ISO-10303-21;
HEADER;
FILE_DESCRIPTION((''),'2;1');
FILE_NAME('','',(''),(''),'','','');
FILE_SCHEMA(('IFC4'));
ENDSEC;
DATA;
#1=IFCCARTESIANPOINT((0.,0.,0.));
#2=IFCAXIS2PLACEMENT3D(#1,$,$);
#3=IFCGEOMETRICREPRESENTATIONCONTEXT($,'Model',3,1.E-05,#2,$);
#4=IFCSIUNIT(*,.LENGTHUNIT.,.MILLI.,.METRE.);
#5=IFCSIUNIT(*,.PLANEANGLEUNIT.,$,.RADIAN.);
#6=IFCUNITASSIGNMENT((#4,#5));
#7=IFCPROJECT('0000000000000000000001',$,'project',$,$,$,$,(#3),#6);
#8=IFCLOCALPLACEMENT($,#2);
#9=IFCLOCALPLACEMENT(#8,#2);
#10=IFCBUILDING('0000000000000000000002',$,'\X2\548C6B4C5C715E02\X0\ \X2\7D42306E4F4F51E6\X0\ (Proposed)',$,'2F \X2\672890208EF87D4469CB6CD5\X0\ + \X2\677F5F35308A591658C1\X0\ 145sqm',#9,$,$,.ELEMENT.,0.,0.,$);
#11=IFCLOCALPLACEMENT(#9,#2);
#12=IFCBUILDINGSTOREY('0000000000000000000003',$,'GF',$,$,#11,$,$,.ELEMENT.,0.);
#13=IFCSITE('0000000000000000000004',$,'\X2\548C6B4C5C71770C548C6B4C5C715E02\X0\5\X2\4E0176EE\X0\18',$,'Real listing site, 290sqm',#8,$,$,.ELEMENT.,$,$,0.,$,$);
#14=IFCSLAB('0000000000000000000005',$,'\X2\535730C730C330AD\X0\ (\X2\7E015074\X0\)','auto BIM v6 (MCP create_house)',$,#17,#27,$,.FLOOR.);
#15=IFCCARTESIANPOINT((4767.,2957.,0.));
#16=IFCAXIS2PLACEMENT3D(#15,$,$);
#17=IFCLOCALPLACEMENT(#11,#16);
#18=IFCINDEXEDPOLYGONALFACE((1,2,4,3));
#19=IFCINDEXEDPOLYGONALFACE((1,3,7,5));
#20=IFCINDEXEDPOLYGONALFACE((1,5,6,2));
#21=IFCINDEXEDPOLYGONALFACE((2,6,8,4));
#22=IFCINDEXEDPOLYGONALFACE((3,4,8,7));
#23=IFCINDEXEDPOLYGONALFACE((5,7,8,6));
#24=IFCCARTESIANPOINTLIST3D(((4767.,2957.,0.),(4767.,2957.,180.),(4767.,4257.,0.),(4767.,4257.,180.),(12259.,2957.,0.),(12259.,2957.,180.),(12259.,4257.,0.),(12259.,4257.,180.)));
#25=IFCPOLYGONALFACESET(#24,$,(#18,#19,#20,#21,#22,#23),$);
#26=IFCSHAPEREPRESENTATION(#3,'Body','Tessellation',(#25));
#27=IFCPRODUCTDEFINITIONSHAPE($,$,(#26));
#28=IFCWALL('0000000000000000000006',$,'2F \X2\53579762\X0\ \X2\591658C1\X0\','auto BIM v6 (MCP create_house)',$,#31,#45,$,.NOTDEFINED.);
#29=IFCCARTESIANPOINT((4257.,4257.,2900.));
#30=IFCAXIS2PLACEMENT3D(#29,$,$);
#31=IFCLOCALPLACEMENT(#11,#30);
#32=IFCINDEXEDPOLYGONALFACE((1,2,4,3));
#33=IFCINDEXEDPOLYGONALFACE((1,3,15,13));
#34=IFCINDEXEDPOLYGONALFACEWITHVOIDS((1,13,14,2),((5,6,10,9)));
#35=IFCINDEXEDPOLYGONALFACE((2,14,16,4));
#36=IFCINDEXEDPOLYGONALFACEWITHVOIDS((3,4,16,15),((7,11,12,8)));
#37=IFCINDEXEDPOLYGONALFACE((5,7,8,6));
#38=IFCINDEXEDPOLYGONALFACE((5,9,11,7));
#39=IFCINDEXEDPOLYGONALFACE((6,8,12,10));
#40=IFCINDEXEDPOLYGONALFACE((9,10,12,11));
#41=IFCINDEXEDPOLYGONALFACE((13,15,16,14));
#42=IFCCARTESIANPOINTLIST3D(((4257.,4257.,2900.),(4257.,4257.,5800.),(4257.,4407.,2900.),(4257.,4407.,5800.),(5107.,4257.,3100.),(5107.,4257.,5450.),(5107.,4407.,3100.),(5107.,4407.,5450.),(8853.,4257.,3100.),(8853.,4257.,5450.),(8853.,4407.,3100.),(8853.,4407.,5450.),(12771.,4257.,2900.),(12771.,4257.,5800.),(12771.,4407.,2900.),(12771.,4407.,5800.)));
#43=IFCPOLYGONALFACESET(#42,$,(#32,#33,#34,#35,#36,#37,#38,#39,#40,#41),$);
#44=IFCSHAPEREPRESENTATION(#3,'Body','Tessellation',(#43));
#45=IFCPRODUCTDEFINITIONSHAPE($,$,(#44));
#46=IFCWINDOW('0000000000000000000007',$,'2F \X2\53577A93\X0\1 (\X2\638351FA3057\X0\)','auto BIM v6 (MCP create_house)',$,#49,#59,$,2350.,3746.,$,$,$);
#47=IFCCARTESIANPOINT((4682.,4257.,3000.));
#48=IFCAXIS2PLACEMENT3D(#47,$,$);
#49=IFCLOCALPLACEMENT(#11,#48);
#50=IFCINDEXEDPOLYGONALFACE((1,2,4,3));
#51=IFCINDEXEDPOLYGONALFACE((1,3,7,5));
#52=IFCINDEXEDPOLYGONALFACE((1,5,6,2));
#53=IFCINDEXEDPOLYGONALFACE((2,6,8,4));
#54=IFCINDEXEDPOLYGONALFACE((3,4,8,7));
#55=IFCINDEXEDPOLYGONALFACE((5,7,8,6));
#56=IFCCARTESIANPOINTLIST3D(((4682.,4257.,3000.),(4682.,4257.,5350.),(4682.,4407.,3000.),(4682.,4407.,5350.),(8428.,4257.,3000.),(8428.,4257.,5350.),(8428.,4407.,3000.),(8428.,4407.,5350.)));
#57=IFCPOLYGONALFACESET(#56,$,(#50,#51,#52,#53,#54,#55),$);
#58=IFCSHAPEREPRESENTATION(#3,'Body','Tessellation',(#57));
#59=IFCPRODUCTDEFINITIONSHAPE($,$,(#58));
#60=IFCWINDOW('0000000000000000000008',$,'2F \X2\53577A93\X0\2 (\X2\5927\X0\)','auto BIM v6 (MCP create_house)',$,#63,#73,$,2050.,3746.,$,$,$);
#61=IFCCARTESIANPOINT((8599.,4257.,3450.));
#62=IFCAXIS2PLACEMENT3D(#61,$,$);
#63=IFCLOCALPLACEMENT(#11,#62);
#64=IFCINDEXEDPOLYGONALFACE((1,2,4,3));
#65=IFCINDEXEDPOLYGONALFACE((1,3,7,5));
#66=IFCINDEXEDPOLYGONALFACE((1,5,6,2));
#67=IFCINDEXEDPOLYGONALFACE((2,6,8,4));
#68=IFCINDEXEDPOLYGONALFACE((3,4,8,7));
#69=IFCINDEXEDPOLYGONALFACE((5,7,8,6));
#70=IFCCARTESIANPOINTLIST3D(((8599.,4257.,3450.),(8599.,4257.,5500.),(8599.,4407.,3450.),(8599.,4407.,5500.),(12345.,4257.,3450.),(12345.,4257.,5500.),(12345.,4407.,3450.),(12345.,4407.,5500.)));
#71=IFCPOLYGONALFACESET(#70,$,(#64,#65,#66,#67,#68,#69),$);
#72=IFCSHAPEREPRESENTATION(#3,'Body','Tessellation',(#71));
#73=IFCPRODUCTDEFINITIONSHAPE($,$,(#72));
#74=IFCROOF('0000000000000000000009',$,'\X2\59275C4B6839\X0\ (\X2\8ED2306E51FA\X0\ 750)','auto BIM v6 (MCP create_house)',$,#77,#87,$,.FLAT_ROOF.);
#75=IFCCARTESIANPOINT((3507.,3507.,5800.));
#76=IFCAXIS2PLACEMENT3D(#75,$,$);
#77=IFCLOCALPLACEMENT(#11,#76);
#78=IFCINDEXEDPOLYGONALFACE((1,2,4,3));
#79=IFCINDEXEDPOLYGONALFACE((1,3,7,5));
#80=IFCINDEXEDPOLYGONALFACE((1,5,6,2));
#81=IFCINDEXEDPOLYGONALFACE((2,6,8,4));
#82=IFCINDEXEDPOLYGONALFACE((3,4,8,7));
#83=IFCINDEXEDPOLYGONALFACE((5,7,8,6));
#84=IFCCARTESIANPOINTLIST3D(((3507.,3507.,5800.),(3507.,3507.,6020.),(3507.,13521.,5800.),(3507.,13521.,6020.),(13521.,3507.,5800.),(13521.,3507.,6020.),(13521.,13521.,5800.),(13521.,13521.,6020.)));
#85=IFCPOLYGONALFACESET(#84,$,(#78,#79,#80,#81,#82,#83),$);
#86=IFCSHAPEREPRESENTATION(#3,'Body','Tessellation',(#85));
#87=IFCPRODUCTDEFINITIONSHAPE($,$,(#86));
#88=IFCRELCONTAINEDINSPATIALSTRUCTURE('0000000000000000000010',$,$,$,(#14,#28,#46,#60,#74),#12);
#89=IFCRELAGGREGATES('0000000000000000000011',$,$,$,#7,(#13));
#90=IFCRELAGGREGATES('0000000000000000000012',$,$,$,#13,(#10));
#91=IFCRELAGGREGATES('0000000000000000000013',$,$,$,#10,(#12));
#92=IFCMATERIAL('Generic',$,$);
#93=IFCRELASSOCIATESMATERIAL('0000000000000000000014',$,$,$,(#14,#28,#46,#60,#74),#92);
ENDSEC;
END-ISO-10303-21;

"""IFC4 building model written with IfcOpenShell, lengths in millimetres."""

from ifc_helpers import new_model, si_unit, frame, frame_2d, origin, place, context, project, spatial, rectangle, extrude, material, element, fill, save


model = new_model("IFC4")

# Units and contexts
model_context = context("Model", 3, precision=1e-05, world=origin())
ifc_project = project(units=[si_unit("LENGTHUNIT", "METRE", prefix="MILLI"), si_unit("PLANEANGLEUNIT", "RADIAN")], contexts=[model_context])

# Site, building, storey
site_placement = place(None, origin())
site = spatial("IfcSite", under=ifc_project, at=site_placement, Name="和歌山県和歌山市5丁目18", ObjectType="Real listing site, 290sqm", CompositionType="ELEMENT", RefElevation=0.0)
building_placement = place(site_placement, origin())
building = spatial("IfcBuilding", under=site, at=building_placement, Name="和歌山市 終の住処 (Proposed)", ObjectType="2F 木造軸組構法 + 板張り外壁 145sqm", CompositionType="ELEMENT", ElevationOfRefHeight=0.0, ElevationOfTerrain=0.0)
storey_placement = place(building_placement, origin())
storey = spatial("IfcBuildingStorey", under=building, at=storey_placement, Name="GF", CompositionType="ELEMENT", Elevation=0.0)

# Slab
ifc_material = material(Name="Generic")
slab_1_placement = place(storey_placement, frame((4767.0, 2957.0, 0.0)))
element("IfcSlab", 1, at=slab_1_placement, inside=storey, material=ifc_material, Name="南デッキ (縁側)", Description="auto BIM v6 (MCP create_house)", PredefinedType="FLOOR", context=model_context, shape_type="SweptSolid", body=[
    extrude(rectangle(XDim=7492.0, YDim=1300.0, at=frame_2d((3746.0, 650.0))), frame((4767.0, 2957.0, 0.0)), (0.0, 0.0, 1.0), 180.0),
])

# Wall, openings, windows
wall_1_placement = place(storey_placement, frame((4257.0, 4257.0, 2900.0)))
wall_1 = element("IfcWall", 2, at=wall_1_placement, inside=storey, material=ifc_material, Name="2F 南面 外壁", Description="auto BIM v6 (MCP create_house)", PredefinedType="NOTDEFINED", context=model_context, shape_type="SweptSolid", body=[
    extrude(rectangle(XDim=8514.0, YDim=150.0, at=frame_2d((4257.0, 75.0))), frame((4257.0, 4257.0, 2900.0)), (0.0, 0.0, 1.0), 2900.0),
])
opening_1_placement = place(storey_placement, frame((4682.0, 4257.0, 3000.0)))
opening_1 = element("IfcOpeningElement", 3, at=opening_1_placement, cuts=wall_1, PredefinedType="NOTDEFINED", context=model_context, shape_type="SweptSolid", body=[
    extrude(rectangle(XDim=3746.0, YDim=150.0, at=frame_2d((1873.0, 75.0))), frame((4682.0, 4257.0, 3000.0)), (0.0, 0.0, 1.0), 2350.0),
])
opening_2_placement = place(storey_placement, frame((8599.0, 4257.0, 3450.0)))
opening_2 = element("IfcOpeningElement", 4, at=opening_2_placement, cuts=wall_1, PredefinedType="NOTDEFINED", context=model_context, shape_type="SweptSolid", body=[
    extrude(rectangle(XDim=3746.0, YDim=150.0, at=frame_2d((1873.0, 75.0))), frame((8599.0, 4257.0, 3450.0)), (0.0, 0.0, 1.0), 2050.0),
])
window_1_placement = place(storey_placement, frame((4682.0, 4257.0, 3000.0)))
window_1 = element("IfcWindow", 5, at=window_1_placement, inside=storey, material=ifc_material, Name="2F 南窓1 (掃出し)", Description="auto BIM v6 (MCP create_house)", OverallHeight=2350.0, OverallWidth=3746.0, context=model_context, shape_type="SweptSolid", body=[
    extrude(rectangle(XDim=3746.0, YDim=150.0, at=frame_2d((1873.0, 75.0))), frame((4682.0, 4257.0, 3000.0)), (0.0, 0.0, 1.0), 2350.0),
])
fill(opening_1, window_1)
window_2_placement = place(storey_placement, frame((8599.0, 4257.0, 3450.0)))
window_2 = element("IfcWindow", 6, at=window_2_placement, inside=storey, material=ifc_material, Name="2F 南窓2 (大)", Description="auto BIM v6 (MCP create_house)", OverallHeight=2050.0, OverallWidth=3746.0, context=model_context, shape_type="SweptSolid", body=[
    extrude(rectangle(XDim=3746.0, YDim=150.0, at=frame_2d((1873.0, 75.0))), frame((8599.0, 4257.0, 3450.0)), (0.0, 0.0, 1.0), 2050.0),
])
fill(opening_2, window_2)

# Roof
roof_placement = place(storey_placement, frame((3507.0, 3507.0, 5800.0)))
element("IfcRoof", 7, at=roof_placement, inside=storey, material=ifc_material, Name="大屋根 (軒の出 750)", Description="auto BIM v6 (MCP create_house)", PredefinedType="FLAT_ROOF", context=model_context, shape_type="SweptSolid", body=[
    extrude(rectangle(XDim=10014.0, YDim=10014.0, at=frame_2d((5007.0, 5007.0))), frame((3507.0, 3507.0, 5800.0)), (0.0, 0.0, 1.0), 220.0),
])

save(model, "model.ifc")
